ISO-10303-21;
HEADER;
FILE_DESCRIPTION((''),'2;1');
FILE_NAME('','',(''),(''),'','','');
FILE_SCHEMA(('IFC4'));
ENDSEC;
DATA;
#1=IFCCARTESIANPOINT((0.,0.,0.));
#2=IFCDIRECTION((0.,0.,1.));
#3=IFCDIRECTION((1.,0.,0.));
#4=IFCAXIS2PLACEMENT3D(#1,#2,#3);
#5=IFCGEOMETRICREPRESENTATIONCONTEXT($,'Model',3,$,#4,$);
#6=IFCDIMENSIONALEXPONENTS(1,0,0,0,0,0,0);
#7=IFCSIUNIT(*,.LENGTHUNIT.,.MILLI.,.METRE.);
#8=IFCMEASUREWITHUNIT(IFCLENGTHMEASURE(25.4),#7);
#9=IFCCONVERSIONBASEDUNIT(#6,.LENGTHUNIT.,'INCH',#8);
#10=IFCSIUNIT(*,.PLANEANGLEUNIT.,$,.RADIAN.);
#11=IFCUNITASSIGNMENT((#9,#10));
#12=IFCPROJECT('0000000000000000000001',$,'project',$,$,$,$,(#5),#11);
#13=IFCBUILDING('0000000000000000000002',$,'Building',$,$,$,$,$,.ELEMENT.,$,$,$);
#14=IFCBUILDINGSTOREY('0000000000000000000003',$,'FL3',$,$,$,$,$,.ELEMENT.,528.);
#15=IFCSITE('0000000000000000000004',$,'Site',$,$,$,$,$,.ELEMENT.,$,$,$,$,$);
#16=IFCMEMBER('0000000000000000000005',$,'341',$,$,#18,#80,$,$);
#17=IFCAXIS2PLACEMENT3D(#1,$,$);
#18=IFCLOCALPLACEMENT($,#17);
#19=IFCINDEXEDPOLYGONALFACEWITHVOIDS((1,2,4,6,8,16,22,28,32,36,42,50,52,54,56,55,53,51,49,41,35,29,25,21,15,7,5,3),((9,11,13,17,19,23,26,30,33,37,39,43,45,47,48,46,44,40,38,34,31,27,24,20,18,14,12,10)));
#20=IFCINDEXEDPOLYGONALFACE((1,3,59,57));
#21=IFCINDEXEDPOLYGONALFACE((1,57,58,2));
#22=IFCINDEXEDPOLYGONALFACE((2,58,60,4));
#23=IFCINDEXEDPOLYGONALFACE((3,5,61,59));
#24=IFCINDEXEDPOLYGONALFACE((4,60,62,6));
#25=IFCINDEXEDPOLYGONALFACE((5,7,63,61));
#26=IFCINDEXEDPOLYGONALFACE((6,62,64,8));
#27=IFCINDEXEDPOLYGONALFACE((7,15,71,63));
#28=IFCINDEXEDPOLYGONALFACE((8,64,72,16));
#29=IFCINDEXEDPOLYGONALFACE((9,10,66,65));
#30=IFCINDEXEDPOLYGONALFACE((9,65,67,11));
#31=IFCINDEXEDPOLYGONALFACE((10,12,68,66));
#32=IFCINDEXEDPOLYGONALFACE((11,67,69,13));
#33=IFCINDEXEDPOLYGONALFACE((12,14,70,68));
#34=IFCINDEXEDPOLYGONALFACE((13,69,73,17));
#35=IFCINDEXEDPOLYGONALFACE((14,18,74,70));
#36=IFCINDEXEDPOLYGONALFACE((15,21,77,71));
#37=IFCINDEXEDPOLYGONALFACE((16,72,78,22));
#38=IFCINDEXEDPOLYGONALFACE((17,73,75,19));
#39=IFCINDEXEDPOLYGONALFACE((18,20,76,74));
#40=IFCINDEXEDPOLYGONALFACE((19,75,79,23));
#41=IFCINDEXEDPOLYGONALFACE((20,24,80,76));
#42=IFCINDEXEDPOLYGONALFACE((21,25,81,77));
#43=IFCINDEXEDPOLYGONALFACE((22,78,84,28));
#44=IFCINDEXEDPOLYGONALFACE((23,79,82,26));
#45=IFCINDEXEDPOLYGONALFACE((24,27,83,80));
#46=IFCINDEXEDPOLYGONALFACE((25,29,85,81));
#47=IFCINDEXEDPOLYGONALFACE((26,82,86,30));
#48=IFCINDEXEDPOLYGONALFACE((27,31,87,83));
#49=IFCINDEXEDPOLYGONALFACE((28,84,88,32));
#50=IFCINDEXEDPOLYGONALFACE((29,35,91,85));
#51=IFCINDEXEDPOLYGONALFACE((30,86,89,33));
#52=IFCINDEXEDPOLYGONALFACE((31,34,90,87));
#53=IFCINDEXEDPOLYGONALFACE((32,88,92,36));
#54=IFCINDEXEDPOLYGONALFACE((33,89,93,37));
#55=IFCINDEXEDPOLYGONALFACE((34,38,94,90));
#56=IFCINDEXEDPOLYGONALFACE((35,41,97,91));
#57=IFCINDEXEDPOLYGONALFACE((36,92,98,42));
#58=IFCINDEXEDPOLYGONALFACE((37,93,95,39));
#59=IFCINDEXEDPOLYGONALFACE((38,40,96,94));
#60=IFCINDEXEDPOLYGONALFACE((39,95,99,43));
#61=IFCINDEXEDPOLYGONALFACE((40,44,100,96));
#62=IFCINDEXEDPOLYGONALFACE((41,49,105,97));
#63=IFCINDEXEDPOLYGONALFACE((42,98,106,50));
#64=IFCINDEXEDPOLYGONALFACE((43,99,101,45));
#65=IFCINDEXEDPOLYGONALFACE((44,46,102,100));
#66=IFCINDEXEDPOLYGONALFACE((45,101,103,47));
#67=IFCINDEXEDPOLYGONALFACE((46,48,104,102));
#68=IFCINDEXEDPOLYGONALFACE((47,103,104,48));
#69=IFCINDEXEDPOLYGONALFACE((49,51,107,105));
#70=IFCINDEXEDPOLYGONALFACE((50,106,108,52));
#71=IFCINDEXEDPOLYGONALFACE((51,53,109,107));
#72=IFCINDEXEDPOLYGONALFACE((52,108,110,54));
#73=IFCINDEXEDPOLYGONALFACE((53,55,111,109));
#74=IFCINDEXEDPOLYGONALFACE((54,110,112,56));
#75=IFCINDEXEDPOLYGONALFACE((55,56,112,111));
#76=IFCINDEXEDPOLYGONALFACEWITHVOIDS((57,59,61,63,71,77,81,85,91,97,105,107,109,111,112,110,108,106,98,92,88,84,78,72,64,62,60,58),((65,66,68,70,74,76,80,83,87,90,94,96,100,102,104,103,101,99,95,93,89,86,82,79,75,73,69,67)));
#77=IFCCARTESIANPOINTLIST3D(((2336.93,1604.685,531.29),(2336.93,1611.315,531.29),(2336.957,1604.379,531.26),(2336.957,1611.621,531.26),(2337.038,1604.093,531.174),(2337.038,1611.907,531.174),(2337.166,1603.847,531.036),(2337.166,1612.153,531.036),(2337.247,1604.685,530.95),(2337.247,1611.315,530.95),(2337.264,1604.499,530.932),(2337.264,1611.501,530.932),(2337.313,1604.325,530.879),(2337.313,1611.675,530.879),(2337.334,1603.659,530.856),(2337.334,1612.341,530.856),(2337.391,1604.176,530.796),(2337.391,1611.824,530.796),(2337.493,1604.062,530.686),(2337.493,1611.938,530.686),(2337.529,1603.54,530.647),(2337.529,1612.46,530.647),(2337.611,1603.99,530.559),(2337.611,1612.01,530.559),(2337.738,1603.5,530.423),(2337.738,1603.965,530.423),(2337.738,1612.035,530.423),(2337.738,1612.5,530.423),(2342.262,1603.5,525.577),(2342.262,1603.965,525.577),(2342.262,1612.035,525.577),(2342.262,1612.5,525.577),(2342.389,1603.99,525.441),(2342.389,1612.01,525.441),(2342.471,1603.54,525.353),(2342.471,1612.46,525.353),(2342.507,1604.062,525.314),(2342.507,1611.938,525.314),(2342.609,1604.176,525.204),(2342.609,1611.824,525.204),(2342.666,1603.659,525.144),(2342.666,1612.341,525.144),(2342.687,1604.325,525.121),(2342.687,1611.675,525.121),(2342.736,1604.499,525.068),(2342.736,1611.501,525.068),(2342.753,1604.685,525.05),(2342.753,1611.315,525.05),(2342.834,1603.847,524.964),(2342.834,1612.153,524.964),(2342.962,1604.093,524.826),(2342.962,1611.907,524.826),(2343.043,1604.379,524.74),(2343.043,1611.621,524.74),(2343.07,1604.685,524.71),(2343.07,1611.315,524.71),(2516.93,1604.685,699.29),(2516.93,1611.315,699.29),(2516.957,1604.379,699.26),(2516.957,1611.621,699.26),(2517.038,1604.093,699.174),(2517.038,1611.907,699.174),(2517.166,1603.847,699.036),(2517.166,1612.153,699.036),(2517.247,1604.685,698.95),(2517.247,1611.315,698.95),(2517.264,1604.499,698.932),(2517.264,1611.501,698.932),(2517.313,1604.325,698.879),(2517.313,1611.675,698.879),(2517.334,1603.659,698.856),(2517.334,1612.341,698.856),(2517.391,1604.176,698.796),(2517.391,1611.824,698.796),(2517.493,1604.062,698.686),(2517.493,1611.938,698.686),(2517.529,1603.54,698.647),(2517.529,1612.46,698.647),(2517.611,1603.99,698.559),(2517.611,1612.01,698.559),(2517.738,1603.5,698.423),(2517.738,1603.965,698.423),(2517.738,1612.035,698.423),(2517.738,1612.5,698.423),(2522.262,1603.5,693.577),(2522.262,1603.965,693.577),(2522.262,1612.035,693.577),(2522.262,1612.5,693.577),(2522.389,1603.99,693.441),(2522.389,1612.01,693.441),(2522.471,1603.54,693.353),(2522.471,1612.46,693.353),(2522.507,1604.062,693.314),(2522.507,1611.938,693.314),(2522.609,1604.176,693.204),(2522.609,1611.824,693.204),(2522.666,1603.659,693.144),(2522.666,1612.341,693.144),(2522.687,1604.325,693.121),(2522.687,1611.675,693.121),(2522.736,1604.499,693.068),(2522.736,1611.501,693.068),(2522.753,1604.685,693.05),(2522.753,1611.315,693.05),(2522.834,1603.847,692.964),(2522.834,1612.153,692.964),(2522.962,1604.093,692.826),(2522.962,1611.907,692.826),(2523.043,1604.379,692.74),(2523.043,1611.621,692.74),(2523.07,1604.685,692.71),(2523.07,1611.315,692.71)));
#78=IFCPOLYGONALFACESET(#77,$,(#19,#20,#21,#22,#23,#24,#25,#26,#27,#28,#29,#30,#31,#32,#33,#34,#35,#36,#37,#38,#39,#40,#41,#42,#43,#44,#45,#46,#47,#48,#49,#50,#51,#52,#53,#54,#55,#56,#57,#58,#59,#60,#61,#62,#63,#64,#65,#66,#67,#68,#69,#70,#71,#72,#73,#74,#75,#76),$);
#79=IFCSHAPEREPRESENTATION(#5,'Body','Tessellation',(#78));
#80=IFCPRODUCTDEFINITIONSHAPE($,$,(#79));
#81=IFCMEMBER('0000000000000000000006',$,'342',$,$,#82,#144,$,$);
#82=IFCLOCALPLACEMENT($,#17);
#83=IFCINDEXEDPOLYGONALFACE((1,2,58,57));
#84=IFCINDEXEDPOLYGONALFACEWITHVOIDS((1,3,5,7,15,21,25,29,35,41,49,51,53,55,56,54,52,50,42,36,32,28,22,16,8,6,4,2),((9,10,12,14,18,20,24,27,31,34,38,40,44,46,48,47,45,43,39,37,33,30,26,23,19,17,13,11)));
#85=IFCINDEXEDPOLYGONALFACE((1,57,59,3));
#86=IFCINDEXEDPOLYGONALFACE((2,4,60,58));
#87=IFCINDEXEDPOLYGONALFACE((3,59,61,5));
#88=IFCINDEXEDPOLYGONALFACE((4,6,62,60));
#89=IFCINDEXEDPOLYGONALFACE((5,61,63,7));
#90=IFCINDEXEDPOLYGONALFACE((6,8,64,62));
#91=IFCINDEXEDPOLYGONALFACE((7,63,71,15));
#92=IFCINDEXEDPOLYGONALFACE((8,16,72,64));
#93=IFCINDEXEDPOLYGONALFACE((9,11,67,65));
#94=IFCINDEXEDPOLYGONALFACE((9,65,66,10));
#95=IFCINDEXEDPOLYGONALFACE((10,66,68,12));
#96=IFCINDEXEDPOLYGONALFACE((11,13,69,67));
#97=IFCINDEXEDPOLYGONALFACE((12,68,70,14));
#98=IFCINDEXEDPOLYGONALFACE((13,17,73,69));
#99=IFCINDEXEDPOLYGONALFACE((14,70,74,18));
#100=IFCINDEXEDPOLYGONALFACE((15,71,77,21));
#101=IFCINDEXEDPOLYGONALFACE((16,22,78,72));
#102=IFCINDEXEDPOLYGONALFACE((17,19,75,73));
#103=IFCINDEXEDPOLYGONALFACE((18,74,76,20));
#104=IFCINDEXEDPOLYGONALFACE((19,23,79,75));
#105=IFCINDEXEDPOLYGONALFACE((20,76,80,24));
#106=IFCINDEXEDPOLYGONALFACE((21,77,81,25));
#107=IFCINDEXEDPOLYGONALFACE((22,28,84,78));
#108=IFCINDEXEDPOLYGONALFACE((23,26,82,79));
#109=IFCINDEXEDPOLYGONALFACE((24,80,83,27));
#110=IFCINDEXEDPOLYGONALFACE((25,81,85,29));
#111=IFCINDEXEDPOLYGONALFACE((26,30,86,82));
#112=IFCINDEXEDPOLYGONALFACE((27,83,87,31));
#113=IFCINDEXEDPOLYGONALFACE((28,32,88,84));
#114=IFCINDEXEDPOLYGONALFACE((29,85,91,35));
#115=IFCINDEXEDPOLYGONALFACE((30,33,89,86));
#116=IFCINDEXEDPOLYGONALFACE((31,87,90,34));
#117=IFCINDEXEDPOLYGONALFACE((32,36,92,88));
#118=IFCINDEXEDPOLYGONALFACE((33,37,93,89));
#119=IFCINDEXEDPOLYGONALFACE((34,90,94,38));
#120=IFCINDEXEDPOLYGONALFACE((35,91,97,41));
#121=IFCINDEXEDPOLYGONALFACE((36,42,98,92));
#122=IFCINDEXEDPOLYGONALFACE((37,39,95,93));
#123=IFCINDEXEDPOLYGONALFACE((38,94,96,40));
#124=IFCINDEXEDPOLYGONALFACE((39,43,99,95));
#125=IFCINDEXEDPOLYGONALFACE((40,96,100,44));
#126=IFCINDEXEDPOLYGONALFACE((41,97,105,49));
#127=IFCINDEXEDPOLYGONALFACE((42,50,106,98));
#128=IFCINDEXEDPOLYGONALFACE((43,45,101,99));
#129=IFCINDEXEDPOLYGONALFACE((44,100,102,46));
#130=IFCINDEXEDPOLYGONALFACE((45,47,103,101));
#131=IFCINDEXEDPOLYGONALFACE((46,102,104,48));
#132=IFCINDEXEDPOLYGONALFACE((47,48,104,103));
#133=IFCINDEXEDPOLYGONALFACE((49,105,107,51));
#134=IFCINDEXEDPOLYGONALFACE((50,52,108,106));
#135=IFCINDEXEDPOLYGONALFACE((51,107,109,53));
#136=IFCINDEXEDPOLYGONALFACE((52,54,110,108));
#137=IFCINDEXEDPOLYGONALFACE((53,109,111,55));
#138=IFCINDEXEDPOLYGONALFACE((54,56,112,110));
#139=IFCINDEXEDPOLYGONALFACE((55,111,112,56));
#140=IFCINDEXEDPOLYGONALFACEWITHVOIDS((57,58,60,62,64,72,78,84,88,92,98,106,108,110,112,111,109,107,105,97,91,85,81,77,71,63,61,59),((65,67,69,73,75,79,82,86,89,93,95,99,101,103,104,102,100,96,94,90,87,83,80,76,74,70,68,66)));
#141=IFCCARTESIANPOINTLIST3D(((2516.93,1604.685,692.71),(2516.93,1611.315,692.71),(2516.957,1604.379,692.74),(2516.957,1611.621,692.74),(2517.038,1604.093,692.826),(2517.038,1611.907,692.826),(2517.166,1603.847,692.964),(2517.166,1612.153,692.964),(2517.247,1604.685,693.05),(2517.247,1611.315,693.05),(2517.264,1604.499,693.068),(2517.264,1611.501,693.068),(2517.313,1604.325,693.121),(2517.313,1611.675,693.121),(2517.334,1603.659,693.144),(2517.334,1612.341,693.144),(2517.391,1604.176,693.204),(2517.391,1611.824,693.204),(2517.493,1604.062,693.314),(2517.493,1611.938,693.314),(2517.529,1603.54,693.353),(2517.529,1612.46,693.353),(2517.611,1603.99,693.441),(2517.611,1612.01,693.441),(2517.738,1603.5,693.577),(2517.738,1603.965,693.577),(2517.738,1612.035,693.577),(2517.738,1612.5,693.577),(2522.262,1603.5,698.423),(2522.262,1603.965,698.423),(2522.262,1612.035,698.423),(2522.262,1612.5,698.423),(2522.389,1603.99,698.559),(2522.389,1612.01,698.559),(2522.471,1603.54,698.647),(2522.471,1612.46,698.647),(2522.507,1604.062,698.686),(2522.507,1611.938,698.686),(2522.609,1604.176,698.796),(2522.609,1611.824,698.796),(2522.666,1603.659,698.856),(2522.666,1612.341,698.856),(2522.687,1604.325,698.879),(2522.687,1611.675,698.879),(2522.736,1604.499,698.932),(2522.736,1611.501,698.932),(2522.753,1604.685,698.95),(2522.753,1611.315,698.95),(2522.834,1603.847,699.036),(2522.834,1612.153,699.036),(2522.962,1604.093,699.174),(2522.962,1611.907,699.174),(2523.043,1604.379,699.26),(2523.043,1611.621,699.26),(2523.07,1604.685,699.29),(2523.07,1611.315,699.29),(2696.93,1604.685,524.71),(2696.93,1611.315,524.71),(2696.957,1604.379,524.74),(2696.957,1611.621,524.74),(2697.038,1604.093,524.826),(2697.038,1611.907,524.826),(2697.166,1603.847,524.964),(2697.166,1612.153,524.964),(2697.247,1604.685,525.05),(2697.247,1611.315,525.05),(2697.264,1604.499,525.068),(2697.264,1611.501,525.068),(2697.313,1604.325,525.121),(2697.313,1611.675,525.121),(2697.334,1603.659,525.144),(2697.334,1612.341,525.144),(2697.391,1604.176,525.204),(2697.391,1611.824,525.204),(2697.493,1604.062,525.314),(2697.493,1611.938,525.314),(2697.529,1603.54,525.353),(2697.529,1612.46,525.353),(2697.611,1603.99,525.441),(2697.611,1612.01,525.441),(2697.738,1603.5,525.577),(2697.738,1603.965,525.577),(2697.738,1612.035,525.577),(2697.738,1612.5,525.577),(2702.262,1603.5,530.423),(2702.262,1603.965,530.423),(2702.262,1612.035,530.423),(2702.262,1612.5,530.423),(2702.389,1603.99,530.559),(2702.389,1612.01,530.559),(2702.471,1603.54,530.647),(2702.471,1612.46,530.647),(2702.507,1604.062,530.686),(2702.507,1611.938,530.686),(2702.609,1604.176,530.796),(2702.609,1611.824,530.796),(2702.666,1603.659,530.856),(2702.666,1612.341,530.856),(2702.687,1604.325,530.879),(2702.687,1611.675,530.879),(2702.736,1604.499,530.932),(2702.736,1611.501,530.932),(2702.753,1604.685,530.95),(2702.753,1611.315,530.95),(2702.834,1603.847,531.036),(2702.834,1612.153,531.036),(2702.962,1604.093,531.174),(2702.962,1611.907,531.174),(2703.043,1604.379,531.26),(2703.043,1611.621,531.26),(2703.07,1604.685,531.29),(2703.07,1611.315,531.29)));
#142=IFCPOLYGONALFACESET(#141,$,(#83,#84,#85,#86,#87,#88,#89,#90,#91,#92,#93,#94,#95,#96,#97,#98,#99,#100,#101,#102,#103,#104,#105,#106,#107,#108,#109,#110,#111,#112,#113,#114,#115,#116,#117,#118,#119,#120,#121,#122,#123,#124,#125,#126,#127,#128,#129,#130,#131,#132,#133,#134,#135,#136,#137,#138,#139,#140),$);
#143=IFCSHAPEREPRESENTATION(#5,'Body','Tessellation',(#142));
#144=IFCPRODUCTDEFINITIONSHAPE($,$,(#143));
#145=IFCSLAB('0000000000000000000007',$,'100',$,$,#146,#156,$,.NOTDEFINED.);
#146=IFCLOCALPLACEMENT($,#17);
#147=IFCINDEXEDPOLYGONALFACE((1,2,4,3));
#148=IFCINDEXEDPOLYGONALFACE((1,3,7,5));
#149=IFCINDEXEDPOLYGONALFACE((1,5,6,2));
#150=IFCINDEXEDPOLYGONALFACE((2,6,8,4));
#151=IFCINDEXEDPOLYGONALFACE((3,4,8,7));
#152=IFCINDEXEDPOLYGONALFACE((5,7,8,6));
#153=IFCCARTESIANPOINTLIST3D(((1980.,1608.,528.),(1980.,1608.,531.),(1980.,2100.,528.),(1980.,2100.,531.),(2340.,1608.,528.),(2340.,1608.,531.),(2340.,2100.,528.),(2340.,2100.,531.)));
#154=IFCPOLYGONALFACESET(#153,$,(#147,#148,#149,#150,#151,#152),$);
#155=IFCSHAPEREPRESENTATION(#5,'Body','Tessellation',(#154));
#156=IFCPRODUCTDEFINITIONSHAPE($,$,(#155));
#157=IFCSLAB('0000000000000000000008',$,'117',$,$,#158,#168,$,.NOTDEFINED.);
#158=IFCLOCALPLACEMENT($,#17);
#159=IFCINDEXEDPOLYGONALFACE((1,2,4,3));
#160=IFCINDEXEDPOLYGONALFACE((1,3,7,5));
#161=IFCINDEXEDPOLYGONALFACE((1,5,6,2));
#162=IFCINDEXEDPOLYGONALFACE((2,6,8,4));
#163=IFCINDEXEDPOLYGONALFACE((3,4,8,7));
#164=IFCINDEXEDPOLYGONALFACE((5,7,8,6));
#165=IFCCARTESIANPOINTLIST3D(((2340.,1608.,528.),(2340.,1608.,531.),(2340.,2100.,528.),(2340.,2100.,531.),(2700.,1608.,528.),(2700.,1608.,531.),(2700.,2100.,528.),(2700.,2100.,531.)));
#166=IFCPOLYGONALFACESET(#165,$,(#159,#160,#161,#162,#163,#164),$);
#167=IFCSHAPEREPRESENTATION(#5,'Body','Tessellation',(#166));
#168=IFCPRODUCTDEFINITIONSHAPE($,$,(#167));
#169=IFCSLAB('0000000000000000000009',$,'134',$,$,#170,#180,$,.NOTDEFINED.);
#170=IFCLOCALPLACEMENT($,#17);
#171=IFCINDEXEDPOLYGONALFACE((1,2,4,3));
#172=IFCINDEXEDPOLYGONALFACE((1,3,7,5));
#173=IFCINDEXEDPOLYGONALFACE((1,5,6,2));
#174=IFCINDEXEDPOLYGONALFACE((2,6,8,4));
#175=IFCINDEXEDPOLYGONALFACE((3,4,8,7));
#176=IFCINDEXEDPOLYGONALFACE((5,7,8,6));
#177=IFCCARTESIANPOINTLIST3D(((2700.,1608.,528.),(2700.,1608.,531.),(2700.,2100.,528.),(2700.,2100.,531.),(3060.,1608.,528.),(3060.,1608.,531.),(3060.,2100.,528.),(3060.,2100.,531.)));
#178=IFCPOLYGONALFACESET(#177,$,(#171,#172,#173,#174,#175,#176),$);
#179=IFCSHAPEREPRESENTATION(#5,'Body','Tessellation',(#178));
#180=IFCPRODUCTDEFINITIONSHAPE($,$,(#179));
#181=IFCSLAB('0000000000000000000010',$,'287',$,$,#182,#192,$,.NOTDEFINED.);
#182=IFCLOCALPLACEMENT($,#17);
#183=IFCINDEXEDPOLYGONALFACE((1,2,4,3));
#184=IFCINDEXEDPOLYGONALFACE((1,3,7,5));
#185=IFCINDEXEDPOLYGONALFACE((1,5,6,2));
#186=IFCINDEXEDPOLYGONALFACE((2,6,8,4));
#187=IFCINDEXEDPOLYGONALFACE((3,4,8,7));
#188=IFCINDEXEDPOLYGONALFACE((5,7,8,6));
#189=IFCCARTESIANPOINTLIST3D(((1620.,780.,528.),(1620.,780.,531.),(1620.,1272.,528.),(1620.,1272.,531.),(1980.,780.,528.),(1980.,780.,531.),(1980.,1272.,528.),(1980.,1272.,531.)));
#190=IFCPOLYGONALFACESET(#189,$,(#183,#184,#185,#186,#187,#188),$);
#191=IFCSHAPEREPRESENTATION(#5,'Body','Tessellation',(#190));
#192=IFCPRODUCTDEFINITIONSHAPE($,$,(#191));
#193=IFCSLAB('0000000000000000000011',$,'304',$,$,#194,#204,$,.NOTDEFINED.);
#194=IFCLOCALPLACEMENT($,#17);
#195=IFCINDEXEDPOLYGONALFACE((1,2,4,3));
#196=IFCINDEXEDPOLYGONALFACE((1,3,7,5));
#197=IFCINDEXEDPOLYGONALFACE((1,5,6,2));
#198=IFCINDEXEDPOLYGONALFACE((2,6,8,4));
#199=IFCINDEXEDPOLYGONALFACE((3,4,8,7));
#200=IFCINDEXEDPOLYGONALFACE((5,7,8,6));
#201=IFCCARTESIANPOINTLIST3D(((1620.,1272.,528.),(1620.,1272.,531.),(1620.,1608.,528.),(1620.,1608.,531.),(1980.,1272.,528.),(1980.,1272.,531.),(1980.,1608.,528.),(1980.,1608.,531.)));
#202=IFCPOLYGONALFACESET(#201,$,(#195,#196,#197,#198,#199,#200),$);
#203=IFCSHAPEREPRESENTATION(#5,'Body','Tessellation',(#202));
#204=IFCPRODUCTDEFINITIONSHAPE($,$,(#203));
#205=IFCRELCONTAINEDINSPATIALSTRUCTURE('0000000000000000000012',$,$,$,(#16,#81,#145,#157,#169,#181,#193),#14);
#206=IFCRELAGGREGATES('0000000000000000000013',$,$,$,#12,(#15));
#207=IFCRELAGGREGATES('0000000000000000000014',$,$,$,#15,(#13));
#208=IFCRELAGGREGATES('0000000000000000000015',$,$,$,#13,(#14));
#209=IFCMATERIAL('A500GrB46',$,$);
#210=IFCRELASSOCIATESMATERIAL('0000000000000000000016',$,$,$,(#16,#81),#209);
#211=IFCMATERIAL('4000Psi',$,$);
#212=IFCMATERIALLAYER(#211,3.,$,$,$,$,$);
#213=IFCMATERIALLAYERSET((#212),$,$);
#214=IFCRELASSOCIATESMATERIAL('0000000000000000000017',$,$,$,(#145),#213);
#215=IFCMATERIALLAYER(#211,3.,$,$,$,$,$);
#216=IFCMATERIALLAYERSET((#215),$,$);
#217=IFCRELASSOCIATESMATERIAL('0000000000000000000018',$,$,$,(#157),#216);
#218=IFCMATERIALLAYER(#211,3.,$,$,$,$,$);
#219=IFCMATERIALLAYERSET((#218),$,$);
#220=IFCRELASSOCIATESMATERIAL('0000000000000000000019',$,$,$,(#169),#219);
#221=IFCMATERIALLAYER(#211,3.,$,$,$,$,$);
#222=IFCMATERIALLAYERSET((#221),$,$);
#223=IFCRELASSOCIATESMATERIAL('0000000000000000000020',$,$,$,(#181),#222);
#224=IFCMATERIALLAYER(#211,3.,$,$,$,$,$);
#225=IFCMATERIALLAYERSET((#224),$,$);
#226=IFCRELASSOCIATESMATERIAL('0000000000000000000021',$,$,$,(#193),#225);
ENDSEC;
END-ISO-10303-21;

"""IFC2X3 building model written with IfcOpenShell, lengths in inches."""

from ifc_helpers import new_model, entity, si_unit, converted_unit, frame, origin_with_axes, origin_2d_with_axis, place, context, project, spatial, polyline, hollow_rectangle, outline, extrude, material, layer, layer_set, layer_usage, element, save


model = new_model("IFC2X3")

# Units and contexts
model_context = context("Model", 3, world=origin_with_axes())
ifc_project = project(units=[converted_unit("LENGTHUNIT", "INCH", entity("IfcLengthMeasure", 25.4), si_unit("LENGTHUNIT", "METRE", prefix="MILLI"), dimensions=[1, 0, 0, 0, 0, 0, 0]), si_unit("PLANEANGLEUNIT", "RADIAN")], contexts=[model_context])

# Site, building, storey
site = spatial("IfcSite", under=ifc_project, Name="Site", CompositionType="ELEMENT")
building = spatial("IfcBuilding", under=site, Name="Building", CompositionType="ELEMENT")
storey = spatial("IfcBuildingStorey", under=building, Name="FL3", CompositionType="ELEMENT", Elevation=528.0)

# Members
ifc_material_1 = material(Name="A500GrB46")
for number, where, z_axis, x_axis, name in (
    (1, (2340.0, 1608.0, 528.0), (0.731055, 0.0, 0.682318), (0.0, 1.0, 0.0), "341"),
    (2, (2700.0, 1608.0, 528.0), (-0.731055, 0.0, 0.682318), (0.0, -1.0, 0.0), "342"),
):
    element("IfcMember", number, at=place(None, frame(where, z_axis=z_axis, x_axis=x_axis)), inside=storey, material=ifc_material_1, Name=name, context=model_context, shape_type="SweptSolid", body=[
        extrude(hollow_rectangle(XDim=9.0, YDim=9.0, WallThickness=0.465, InnerFilletRadius=0.72, OuterFilletRadius=1.185, at=origin_2d_with_axis()), origin_with_axes(), (0.0, 0.0, 1.0), 246.219),
    ])

# Slabs
ifc_material_2 = material(Name="4000Psi")
ifc_layer_1 = layer(ifc_material_2, 3.0)
ifc_layer_set_1 = layer_set([ifc_layer_1])
ifc_layer_usage_1 = layer_usage(ifc_layer_set_1, "AXIS2", "POSITIVE", -3.0)
slab_1_placement = place(None, frame((1980.0, 1608.0, 528.0), z_axis=(0.0, 0.0, 1.0), x_axis=(1.0, 0.0, 0.0)))
element("IfcSlab", 3, at=slab_1_placement, inside=storey, material=ifc_layer_usage_1, Name="100", PredefinedType="NOTDEFINED", context=model_context, shape_type="SweptSolid", body=[
    extrude(outline(polyline([(0.0, 0.0), (360.0, 0.0), (360.0, 492.0), (0.0, 492.0), (0.0, 0.0)])), origin_with_axes(), (0.0, 0.0, 1.0), 3.0),
])
ifc_layer_2 = layer(ifc_material_2, 3.0)
ifc_layer_set_2 = layer_set([ifc_layer_2])
ifc_layer_usage_2 = layer_usage(ifc_layer_set_2, "AXIS2", "POSITIVE", -3.0)
slab_2_placement = place(None, frame((2340.0, 1608.0, 528.0), z_axis=(0.0, 0.0, 1.0), x_axis=(1.0, 0.0, 0.0)))
element("IfcSlab", 4, at=slab_2_placement, inside=storey, material=ifc_layer_usage_2, Name="117", PredefinedType="NOTDEFINED", context=model_context, shape_type="SweptSolid", body=[
    extrude(outline(polyline([(0.0, 0.0), (360.0, 0.0), (360.0, 492.0), (0.0, 492.0), (0.0, 0.0)])), origin_with_axes(), (0.0, 0.0, 1.0), 3.0),
])
ifc_layer_3 = layer(ifc_material_2, 3.0)
ifc_layer_set_3 = layer_set([ifc_layer_3])
ifc_layer_usage_3 = layer_usage(ifc_layer_set_3, "AXIS2", "POSITIVE", -3.0)
slab_3_placement = place(None, frame((2700.0, 1608.0, 528.0), z_axis=(0.0, 0.0, 1.0), x_axis=(1.0, 0.0, 0.0)))
element("IfcSlab", 5, at=slab_3_placement, inside=storey, material=ifc_layer_usage_3, Name="134", PredefinedType="NOTDEFINED", context=model_context, shape_type="SweptSolid", body=[
    extrude(outline(polyline([(0.0, 0.0), (360.0, 0.0), (360.0, 492.0), (0.0, 492.0), (0.0, 0.0)])), origin_with_axes(), (0.0, 0.0, 1.0), 3.0),
])
ifc_layer_4 = layer(ifc_material_2, 3.0)
ifc_layer_set_4 = layer_set([ifc_layer_4])
ifc_layer_usage_4 = layer_usage(ifc_layer_set_4, "AXIS2", "POSITIVE", -3.0)
slab_4_placement = place(None, frame((1620.0, 780.0, 528.0), z_axis=(0.0, 0.0, 1.0), x_axis=(1.0, 0.0, 0.0)))
element("IfcSlab", 6, at=slab_4_placement, inside=storey, material=ifc_layer_usage_4, Name="287", PredefinedType="NOTDEFINED", context=model_context, shape_type="SweptSolid", body=[
    extrude(outline(polyline([(0.0, 0.0), (360.0, 0.0), (360.0, 492.0), (0.0, 492.0), (0.0, 0.0)])), origin_with_axes(), (0.0, 0.0, 1.0), 3.0),
])
ifc_layer_5 = layer(ifc_material_2, 3.0)
ifc_layer_set_5 = layer_set([ifc_layer_5])
ifc_layer_usage_5 = layer_usage(ifc_layer_set_5, "AXIS2", "POSITIVE", -3.0)
slab_5_placement = place(None, frame((1620.0, 1272.0, 528.0), z_axis=(0.0, 0.0, 1.0), x_axis=(1.0, 0.0, 0.0)))
element("IfcSlab", 7, at=slab_5_placement, inside=storey, material=ifc_layer_usage_5, Name="304", PredefinedType="NOTDEFINED", context=model_context, shape_type="SweptSolid", body=[
    extrude(outline(polyline([(0.0, 0.0), (360.0, 0.0), (360.0, 336.0), (0.0, 336.0), (0.0, 0.0)])), origin_with_axes(), (0.0, 0.0, 1.0), 3.0),
])

save(model, "model.ifc")
